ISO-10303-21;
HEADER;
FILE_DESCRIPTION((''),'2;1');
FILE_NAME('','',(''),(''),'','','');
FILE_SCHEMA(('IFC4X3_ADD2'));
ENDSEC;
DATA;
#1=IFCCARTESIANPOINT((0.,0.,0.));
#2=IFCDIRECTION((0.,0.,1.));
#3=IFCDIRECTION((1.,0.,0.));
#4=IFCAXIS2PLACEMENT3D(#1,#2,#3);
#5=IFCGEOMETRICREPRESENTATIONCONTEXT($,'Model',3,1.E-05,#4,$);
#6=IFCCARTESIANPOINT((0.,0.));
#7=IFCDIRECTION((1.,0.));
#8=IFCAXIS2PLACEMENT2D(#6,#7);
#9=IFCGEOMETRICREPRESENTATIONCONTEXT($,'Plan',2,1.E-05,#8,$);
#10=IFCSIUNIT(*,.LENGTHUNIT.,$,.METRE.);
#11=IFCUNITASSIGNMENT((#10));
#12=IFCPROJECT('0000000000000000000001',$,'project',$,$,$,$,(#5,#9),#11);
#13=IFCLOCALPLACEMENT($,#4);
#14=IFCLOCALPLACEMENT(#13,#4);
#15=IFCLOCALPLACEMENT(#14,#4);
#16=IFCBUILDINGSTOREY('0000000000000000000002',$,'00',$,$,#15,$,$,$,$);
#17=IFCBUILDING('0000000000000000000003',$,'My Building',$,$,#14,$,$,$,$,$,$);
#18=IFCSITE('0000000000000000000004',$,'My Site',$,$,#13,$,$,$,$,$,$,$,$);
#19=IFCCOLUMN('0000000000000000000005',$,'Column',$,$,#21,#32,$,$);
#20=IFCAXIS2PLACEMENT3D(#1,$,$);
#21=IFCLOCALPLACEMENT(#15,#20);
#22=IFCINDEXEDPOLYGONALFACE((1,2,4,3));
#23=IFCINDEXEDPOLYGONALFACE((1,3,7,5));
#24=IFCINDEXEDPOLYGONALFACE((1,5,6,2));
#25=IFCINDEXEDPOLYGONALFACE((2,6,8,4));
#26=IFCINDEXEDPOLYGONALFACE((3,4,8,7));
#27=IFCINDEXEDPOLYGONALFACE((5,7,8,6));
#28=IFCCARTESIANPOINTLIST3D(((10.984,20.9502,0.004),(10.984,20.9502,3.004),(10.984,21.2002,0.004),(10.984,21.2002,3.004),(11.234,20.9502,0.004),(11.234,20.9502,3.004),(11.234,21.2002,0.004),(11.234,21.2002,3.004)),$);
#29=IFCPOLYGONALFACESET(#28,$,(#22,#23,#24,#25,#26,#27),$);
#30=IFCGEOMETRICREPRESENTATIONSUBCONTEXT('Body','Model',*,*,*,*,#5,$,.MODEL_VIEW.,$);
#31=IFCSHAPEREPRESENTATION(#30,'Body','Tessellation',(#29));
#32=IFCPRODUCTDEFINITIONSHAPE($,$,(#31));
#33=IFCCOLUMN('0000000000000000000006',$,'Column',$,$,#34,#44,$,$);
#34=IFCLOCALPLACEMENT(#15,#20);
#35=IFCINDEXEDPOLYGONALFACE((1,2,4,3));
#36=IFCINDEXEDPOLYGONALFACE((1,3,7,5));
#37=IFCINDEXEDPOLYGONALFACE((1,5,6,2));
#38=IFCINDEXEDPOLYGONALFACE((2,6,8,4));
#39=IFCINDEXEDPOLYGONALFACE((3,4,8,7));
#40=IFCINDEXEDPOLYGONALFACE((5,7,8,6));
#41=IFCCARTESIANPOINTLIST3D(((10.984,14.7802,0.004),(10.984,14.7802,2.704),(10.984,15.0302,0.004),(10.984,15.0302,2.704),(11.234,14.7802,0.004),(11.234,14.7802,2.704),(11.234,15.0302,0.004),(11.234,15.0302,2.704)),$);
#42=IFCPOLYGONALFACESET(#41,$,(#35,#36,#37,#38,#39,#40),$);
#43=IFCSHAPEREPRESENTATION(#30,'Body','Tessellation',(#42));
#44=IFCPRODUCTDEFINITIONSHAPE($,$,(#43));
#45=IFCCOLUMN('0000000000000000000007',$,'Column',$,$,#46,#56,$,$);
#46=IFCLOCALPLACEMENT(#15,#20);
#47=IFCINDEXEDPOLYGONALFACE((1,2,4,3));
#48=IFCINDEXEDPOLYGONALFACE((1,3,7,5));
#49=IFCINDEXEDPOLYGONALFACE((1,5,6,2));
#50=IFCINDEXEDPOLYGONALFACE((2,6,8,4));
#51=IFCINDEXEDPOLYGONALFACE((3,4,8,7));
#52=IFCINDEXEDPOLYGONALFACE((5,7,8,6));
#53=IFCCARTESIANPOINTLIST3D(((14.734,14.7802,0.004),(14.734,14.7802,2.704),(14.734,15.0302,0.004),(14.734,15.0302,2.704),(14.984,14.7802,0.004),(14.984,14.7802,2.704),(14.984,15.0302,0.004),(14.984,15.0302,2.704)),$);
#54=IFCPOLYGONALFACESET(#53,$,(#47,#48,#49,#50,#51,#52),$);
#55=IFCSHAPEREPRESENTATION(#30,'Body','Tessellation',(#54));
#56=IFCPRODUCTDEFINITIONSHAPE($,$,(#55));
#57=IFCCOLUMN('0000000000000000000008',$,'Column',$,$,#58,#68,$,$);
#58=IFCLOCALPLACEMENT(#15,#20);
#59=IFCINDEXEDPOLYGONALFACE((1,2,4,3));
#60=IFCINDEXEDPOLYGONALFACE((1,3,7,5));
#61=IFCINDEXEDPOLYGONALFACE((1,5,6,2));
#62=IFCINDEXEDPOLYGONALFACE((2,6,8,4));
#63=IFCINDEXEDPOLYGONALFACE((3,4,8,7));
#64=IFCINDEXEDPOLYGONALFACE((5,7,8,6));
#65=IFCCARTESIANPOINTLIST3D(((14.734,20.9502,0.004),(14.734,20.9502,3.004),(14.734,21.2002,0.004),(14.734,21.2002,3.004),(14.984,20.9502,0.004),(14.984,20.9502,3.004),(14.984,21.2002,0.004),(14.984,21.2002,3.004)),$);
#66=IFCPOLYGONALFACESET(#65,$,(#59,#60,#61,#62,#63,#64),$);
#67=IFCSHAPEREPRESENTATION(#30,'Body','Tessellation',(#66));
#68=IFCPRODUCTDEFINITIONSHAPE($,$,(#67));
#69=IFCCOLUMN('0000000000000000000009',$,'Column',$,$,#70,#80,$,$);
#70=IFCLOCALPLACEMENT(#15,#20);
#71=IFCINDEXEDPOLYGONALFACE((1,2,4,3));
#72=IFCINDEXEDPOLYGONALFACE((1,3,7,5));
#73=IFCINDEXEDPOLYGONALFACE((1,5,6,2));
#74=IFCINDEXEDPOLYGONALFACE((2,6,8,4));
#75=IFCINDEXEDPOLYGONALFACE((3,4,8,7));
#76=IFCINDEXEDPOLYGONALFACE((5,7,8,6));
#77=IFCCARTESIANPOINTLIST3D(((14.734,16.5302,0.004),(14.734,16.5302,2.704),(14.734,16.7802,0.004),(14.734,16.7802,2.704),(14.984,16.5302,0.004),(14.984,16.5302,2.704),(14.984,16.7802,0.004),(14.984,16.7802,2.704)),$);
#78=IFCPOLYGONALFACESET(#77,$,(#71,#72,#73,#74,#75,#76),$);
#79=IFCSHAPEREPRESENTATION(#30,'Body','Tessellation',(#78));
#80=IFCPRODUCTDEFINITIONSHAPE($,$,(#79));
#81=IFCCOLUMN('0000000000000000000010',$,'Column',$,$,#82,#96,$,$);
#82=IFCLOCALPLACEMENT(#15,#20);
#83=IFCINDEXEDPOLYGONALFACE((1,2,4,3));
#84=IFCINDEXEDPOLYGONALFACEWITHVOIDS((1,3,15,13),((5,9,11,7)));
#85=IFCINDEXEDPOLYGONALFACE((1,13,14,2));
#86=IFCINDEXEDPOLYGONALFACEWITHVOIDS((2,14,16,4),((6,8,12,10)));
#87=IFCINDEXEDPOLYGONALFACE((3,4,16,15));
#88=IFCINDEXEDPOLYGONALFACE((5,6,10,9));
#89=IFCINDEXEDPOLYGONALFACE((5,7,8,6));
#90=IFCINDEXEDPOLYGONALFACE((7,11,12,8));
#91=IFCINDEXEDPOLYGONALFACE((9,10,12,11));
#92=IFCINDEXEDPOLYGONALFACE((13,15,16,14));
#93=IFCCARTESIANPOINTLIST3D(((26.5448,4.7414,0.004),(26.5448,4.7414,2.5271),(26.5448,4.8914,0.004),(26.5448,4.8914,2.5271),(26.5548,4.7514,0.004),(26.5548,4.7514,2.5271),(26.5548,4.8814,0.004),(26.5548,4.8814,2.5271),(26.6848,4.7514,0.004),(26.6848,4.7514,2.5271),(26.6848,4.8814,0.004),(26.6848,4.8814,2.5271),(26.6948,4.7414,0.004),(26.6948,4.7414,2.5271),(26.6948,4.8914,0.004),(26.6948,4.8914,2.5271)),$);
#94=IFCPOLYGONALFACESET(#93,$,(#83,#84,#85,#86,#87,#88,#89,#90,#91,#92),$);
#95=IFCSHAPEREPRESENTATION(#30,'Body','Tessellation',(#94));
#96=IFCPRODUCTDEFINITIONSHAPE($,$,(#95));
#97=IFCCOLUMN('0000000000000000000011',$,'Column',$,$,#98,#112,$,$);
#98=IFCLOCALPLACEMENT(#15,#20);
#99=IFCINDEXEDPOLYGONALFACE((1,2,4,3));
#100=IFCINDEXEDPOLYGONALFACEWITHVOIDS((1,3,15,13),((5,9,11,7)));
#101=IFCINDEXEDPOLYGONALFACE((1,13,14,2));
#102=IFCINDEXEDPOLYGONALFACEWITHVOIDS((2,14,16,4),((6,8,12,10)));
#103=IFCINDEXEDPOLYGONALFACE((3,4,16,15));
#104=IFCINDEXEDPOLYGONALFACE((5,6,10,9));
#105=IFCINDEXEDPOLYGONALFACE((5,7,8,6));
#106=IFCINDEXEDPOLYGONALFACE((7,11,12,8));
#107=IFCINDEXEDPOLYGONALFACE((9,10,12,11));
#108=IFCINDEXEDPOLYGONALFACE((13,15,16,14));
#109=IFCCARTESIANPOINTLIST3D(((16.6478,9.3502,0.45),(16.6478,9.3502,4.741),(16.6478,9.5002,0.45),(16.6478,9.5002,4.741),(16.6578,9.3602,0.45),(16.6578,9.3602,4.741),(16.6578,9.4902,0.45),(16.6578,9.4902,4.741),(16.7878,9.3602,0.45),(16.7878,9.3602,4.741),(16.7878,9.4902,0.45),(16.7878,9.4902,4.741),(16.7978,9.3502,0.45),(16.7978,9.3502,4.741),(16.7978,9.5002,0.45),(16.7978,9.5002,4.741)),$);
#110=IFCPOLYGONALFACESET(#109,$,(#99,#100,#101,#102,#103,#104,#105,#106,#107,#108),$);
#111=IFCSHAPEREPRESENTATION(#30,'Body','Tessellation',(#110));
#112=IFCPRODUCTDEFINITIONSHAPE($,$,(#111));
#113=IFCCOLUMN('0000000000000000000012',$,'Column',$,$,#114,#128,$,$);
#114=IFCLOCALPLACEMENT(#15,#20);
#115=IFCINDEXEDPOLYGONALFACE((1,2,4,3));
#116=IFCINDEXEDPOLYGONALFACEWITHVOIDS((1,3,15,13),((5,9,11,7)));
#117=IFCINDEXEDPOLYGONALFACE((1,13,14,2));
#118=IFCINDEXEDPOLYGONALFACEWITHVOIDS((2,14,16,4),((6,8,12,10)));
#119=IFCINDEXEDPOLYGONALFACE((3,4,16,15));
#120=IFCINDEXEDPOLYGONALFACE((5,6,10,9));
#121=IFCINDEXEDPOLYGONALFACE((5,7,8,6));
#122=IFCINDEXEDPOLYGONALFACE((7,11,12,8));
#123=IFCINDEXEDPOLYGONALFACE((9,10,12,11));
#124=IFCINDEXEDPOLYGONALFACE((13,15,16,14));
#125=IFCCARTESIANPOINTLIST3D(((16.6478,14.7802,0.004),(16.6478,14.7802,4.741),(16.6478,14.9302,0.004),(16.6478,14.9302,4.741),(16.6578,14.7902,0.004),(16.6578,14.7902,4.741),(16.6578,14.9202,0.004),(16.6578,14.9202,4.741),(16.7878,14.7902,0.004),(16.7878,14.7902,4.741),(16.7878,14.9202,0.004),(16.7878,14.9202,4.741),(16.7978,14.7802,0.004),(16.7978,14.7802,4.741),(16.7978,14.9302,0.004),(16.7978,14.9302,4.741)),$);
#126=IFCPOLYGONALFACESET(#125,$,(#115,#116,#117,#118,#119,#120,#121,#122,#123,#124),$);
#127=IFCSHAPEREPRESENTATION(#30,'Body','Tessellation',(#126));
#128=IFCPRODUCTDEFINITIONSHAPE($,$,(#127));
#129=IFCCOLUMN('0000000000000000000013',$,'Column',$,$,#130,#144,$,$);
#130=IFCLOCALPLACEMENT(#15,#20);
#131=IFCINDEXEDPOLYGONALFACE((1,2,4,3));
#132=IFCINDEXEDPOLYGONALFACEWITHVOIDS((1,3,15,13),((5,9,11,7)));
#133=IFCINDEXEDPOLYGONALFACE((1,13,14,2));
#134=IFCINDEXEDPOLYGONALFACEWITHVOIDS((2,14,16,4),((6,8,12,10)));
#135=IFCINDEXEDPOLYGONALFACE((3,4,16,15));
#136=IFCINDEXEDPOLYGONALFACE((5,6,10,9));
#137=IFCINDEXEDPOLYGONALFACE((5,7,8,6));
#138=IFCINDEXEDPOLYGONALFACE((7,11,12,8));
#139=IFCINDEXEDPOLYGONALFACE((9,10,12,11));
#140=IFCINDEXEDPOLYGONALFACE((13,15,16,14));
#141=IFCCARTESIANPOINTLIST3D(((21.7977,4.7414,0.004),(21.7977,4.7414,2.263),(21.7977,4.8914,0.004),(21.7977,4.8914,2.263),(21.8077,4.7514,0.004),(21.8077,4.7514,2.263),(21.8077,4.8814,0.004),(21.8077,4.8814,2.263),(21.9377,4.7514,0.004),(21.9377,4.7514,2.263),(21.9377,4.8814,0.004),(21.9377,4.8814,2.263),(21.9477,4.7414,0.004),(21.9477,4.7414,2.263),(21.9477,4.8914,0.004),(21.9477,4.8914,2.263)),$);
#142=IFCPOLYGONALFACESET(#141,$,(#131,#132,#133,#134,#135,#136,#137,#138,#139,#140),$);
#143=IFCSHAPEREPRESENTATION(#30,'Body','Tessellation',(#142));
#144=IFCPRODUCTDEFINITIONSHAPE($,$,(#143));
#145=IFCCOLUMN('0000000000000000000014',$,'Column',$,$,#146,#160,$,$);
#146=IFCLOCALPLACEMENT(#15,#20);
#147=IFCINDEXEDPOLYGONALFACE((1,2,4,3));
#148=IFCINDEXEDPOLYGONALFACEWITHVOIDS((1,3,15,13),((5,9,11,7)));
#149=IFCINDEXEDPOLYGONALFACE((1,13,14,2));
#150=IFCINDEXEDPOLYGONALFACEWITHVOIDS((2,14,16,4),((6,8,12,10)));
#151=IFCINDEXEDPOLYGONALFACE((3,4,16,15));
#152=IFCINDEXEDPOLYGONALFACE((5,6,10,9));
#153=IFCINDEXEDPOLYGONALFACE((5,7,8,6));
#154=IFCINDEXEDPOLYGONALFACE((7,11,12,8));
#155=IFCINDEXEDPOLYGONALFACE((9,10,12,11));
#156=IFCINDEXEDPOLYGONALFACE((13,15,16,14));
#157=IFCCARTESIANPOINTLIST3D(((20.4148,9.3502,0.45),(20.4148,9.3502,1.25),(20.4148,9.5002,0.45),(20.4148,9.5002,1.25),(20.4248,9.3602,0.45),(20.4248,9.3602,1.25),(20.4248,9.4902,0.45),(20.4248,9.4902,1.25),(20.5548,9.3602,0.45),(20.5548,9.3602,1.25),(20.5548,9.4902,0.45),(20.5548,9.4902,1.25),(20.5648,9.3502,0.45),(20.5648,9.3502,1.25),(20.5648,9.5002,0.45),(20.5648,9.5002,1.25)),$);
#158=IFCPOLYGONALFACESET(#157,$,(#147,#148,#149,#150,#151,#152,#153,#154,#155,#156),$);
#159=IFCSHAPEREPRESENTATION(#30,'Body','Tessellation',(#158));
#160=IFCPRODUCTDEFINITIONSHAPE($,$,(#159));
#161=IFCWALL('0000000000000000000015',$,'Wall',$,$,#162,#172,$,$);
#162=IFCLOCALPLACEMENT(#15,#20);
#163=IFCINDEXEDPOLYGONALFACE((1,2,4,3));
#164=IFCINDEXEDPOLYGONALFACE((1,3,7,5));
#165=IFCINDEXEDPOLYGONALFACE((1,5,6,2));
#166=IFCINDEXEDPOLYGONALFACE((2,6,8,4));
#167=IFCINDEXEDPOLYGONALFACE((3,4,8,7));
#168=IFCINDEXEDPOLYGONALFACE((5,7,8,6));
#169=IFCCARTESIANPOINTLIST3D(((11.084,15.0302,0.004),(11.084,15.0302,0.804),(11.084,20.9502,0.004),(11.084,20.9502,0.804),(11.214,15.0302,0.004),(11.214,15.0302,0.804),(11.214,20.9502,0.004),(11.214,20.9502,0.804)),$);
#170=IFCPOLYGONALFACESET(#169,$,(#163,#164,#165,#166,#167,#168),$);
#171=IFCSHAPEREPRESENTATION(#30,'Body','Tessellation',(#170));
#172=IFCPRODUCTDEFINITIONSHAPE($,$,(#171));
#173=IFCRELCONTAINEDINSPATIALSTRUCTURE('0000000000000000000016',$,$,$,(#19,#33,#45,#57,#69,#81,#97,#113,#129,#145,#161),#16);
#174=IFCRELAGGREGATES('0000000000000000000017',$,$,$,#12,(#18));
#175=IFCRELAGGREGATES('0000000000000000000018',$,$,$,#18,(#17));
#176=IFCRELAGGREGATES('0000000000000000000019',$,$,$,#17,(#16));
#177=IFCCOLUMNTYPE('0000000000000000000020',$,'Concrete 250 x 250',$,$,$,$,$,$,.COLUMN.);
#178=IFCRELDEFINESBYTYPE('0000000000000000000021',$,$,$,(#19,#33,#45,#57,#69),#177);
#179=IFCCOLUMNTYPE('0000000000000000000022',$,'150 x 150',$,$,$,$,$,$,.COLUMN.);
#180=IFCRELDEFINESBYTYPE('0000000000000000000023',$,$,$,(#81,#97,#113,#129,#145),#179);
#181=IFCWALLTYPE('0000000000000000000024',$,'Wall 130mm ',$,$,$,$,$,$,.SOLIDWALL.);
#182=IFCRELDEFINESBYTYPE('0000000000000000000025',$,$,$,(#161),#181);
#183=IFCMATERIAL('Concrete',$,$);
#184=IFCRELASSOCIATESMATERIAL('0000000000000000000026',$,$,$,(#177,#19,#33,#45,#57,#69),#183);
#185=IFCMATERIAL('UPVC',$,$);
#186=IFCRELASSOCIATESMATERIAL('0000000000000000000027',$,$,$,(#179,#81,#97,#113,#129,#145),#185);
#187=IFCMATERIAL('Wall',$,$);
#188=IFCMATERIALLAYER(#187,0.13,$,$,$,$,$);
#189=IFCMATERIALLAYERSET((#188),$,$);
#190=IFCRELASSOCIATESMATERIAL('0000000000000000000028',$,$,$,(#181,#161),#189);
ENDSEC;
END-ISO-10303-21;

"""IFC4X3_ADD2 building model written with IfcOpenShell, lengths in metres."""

from ifc_helpers import new_model, si_unit, frame, origin_with_axes, origin_2d_with_axis, place, context, subcontext, project, spatial, indexed_curve, rectangle, hollow_rectangle, outline, extrude, material, layer, layer_set, layer_usage, material_profile, profile_set, profile_usage, type_object, element, save


model = new_model("IFC4X3_ADD2")

# Units and contexts
model_context = context("Model", 3, precision=1e-05, world=origin_with_axes())
plan_context = context("Plan", 2, precision=1e-05, world=origin_2d_with_axis())
body_context = subcontext(model_context, "Body", "Model", "MODEL_VIEW")
ifc_project = project(units=[si_unit("LENGTHUNIT", "METRE")], contexts=[model_context, plan_context])

# Site, building, storey
site_placement = place(None, origin_with_axes())
site = spatial("IfcSite", under=ifc_project, at=site_placement, Name="My Site")
building_placement = place(site_placement, origin_with_axes())
building = spatial("IfcBuilding", under=site, at=building_placement, Name="My Building")
storey_placement = place(building_placement, origin_with_axes())
storey = spatial("IfcBuildingStorey", under=building, at=storey_placement, Name="00")

# Columns
ifc_material_1 = material(Name="Concrete")
ifc_material_profile_1 = material_profile(ifc_material_1, rectangle(XDim=0.25, YDim=0.25))
ifc_profile_set_1 = profile_set([ifc_material_profile_1])
ifc_profile_usage_1 = profile_usage(ifc_profile_set_1, cardinal=5)
column_type_1 = type_object("IfcColumnType", Name="Concrete 250 x 250", PredefinedType="COLUMN", material=ifc_profile_set_1)
column_1_placement = place(storey_placement, frame((11.109, 21.0752, 0.004), z_axis=(0.0, 0.0, 1.0), x_axis=(1.0, 0.0, 0.0)))
element("IfcColumn", 1, at=column_1_placement, inside=storey, type_object=column_type_1, material=ifc_profile_usage_1, Name="Column", context=body_context, shape_type="SweptSolid", body=[
    extrude(rectangle(XDim=0.25, YDim=0.25), origin_with_axes(), (0.0, 0.0, 1.0), 3.0),
])
ifc_profile_usage_2 = profile_usage(ifc_profile_set_1, cardinal=5)
column_2_placement = place(storey_placement, frame((11.109, 14.9052, 0.004), z_axis=(0.0, 0.0, 1.0), x_axis=(1.0, 0.0, 0.0)))
element("IfcColumn", 2, at=column_2_placement, inside=storey, type_object=column_type_1, material=ifc_profile_usage_2, Name="Column", context=body_context, shape_type="SweptSolid", body=[
    extrude(rectangle(XDim=0.25, YDim=0.25), origin_with_axes(), (0.0, 0.0, 1.0), 2.7),
])
ifc_profile_usage_3 = profile_usage(ifc_profile_set_1, cardinal=5)
column_3_placement = place(storey_placement, frame((14.859, 14.9052, 0.004), z_axis=(0.0, 0.0, 1.0), x_axis=(1.0, 0.0, 0.0)))
element("IfcColumn", 3, at=column_3_placement, inside=storey, type_object=column_type_1, material=ifc_profile_usage_3, Name="Column", context=body_context, shape_type="SweptSolid", body=[
    extrude(rectangle(XDim=0.25, YDim=0.25), origin_with_axes(), (0.0, 0.0, 1.0), 2.7),
])
ifc_profile_usage_4 = profile_usage(ifc_profile_set_1, cardinal=5)
column_4_placement = place(storey_placement, frame((14.859, 21.0752, 0.004), z_axis=(0.0, 0.0, 1.0), x_axis=(1.0, 0.0, 0.0)))
element("IfcColumn", 4, at=column_4_placement, inside=storey, type_object=column_type_1, material=ifc_profile_usage_4, Name="Column", context=body_context, shape_type="SweptSolid", body=[
    extrude(rectangle(XDim=0.25, YDim=0.25), origin_with_axes(), (0.0, 0.0, 1.0), 3.0),
])
ifc_profile_usage_5 = profile_usage(ifc_profile_set_1, cardinal=5)
column_5_placement = place(storey_placement, frame((14.859, 16.6552, 0.004), z_axis=(0.0, 0.0, 1.0), x_axis=(1.0, 0.0, 0.0)))
element("IfcColumn", 5, at=column_5_placement, inside=storey, type_object=column_type_1, material=ifc_profile_usage_5, Name="Column", context=body_context, shape_type="SweptSolid", body=[
    extrude(rectangle(XDim=0.25, YDim=0.25), origin_with_axes(), (0.0, 0.0, 1.0), 2.7),
])
ifc_material_2 = material(Name="UPVC")
ifc_material_profile_2 = material_profile(ifc_material_2, hollow_rectangle(XDim=0.15, YDim=0.15, WallThickness=0.01))
ifc_profile_set_2 = profile_set([ifc_material_profile_2])
ifc_profile_usage_6 = profile_usage(ifc_profile_set_2, cardinal=5)
column_type_2 = type_object("IfcColumnType", Name="150 x 150", PredefinedType="COLUMN", material=ifc_profile_set_2)
column_6_placement = place(storey_placement, frame((26.6198, 4.8164, 0.004), z_axis=(0.0, 0.0, 1.0), x_axis=(1.0, 0.0, 0.0)))
element("IfcColumn", 6, at=column_6_placement, inside=storey, type_object=column_type_2, material=ifc_profile_usage_6, Name="Column", context=body_context, shape_type="SweptSolid", body=[
    extrude(hollow_rectangle(XDim=0.15, YDim=0.15, WallThickness=0.01), origin_with_axes(), (0.0, 0.0, 1.0), 2.5231),
])
ifc_profile_usage_7 = profile_usage(ifc_profile_set_2, cardinal=5)
column_7_placement = place(storey_placement, frame((16.7228, 9.4252, 0.45), z_axis=(0.0, 0.0, 1.0), x_axis=(1.0, 0.0, 0.0)))
element("IfcColumn", 7, at=column_7_placement, inside=storey, type_object=column_type_2, material=ifc_profile_usage_7, Name="Column", context=body_context, shape_type="SweptSolid", body=[
    extrude(hollow_rectangle(XDim=0.15, YDim=0.15, WallThickness=0.01), origin_with_axes(), (0.0, 0.0, 1.0), 4.291),
])
ifc_profile_usage_8 = profile_usage(ifc_profile_set_2, cardinal=5)
column_8_placement = place(storey_placement, frame((16.7228, 14.8552, 0.004), z_axis=(0.0, 0.0, 1.0), x_axis=(1.0, 0.0, 0.0)))
element("IfcColumn", 8, at=column_8_placement, inside=storey, type_object=column_type_2, material=ifc_profile_usage_8, Name="Column", context=body_context, shape_type="SweptSolid", body=[
    extrude(hollow_rectangle(XDim=0.15, YDim=0.15, WallThickness=0.01), origin_with_axes(), (0.0, 0.0, 1.0), 4.737),
])
ifc_profile_usage_9 = profile_usage(ifc_profile_set_2, cardinal=5)
column_9_placement = place(storey_placement, frame((21.8727, 4.8164, 0.004), z_axis=(0.0, 0.0, 1.0), x_axis=(1.0, 0.0, 0.0)))
element("IfcColumn", 9, at=column_9_placement, inside=storey, type_object=column_type_2, material=ifc_profile_usage_9, Name="Column", context=body_context, shape_type="SweptSolid", body=[
    extrude(hollow_rectangle(XDim=0.15, YDim=0.15, WallThickness=0.01), origin_with_axes(), (0.0, 0.0, 1.0), 2.259),
])
ifc_profile_usage_10 = profile_usage(ifc_profile_set_2, cardinal=5)
column_10_placement = place(storey_placement, frame((20.4898, 9.4252, 0.45), z_axis=(0.0, 0.0, 1.0), x_axis=(1.0, 0.0, 0.0)))
element("IfcColumn", 10, at=column_10_placement, inside=storey, type_object=column_type_2, material=ifc_profile_usage_10, Name="Column", context=body_context, shape_type="SweptSolid", body=[
    extrude(hollow_rectangle(XDim=0.15, YDim=0.15, WallThickness=0.01), origin_with_axes(), (0.0, 0.0, 1.0), 0.8),
])

# Wall
ifc_material_3 = material(Name="Wall")
ifc_layer_1 = layer(ifc_material_3, 0.13)
ifc_layer_set_1 = layer_set([ifc_layer_1])
ifc_layer_usage_1 = layer_usage(ifc_layer_set_1, "AXIS2", "POSITIVE", 0.0)
wall_type_1 = type_object("IfcWallType", Name="Wall 130mm ", PredefinedType="SOLIDWALL", material=ifc_layer_set_1)
wall_1_placement = place(storey_placement, frame((11.214, 15.0302, 0.004), z_axis=(0.0, 0.0, 1.0), x_axis=(0.000001, 1.0, 0.0)))
element("IfcWall", 11, at=wall_1_placement, inside=storey, type_object=wall_type_1, material=ifc_layer_usage_1, Name="Wall", context=body_context, shape_type="SweptSolid", body=[
    extrude(outline(indexed_curve([(0.0, 0.0), (0.0, 0.13), (5.92, 0.13), (5.92, 0.0), (0.0, 0.0)], self_intersect=False)), origin_with_axes(), (0.0, 0.0, 1.0), 0.8),
])

save(model, "model.ifc")
